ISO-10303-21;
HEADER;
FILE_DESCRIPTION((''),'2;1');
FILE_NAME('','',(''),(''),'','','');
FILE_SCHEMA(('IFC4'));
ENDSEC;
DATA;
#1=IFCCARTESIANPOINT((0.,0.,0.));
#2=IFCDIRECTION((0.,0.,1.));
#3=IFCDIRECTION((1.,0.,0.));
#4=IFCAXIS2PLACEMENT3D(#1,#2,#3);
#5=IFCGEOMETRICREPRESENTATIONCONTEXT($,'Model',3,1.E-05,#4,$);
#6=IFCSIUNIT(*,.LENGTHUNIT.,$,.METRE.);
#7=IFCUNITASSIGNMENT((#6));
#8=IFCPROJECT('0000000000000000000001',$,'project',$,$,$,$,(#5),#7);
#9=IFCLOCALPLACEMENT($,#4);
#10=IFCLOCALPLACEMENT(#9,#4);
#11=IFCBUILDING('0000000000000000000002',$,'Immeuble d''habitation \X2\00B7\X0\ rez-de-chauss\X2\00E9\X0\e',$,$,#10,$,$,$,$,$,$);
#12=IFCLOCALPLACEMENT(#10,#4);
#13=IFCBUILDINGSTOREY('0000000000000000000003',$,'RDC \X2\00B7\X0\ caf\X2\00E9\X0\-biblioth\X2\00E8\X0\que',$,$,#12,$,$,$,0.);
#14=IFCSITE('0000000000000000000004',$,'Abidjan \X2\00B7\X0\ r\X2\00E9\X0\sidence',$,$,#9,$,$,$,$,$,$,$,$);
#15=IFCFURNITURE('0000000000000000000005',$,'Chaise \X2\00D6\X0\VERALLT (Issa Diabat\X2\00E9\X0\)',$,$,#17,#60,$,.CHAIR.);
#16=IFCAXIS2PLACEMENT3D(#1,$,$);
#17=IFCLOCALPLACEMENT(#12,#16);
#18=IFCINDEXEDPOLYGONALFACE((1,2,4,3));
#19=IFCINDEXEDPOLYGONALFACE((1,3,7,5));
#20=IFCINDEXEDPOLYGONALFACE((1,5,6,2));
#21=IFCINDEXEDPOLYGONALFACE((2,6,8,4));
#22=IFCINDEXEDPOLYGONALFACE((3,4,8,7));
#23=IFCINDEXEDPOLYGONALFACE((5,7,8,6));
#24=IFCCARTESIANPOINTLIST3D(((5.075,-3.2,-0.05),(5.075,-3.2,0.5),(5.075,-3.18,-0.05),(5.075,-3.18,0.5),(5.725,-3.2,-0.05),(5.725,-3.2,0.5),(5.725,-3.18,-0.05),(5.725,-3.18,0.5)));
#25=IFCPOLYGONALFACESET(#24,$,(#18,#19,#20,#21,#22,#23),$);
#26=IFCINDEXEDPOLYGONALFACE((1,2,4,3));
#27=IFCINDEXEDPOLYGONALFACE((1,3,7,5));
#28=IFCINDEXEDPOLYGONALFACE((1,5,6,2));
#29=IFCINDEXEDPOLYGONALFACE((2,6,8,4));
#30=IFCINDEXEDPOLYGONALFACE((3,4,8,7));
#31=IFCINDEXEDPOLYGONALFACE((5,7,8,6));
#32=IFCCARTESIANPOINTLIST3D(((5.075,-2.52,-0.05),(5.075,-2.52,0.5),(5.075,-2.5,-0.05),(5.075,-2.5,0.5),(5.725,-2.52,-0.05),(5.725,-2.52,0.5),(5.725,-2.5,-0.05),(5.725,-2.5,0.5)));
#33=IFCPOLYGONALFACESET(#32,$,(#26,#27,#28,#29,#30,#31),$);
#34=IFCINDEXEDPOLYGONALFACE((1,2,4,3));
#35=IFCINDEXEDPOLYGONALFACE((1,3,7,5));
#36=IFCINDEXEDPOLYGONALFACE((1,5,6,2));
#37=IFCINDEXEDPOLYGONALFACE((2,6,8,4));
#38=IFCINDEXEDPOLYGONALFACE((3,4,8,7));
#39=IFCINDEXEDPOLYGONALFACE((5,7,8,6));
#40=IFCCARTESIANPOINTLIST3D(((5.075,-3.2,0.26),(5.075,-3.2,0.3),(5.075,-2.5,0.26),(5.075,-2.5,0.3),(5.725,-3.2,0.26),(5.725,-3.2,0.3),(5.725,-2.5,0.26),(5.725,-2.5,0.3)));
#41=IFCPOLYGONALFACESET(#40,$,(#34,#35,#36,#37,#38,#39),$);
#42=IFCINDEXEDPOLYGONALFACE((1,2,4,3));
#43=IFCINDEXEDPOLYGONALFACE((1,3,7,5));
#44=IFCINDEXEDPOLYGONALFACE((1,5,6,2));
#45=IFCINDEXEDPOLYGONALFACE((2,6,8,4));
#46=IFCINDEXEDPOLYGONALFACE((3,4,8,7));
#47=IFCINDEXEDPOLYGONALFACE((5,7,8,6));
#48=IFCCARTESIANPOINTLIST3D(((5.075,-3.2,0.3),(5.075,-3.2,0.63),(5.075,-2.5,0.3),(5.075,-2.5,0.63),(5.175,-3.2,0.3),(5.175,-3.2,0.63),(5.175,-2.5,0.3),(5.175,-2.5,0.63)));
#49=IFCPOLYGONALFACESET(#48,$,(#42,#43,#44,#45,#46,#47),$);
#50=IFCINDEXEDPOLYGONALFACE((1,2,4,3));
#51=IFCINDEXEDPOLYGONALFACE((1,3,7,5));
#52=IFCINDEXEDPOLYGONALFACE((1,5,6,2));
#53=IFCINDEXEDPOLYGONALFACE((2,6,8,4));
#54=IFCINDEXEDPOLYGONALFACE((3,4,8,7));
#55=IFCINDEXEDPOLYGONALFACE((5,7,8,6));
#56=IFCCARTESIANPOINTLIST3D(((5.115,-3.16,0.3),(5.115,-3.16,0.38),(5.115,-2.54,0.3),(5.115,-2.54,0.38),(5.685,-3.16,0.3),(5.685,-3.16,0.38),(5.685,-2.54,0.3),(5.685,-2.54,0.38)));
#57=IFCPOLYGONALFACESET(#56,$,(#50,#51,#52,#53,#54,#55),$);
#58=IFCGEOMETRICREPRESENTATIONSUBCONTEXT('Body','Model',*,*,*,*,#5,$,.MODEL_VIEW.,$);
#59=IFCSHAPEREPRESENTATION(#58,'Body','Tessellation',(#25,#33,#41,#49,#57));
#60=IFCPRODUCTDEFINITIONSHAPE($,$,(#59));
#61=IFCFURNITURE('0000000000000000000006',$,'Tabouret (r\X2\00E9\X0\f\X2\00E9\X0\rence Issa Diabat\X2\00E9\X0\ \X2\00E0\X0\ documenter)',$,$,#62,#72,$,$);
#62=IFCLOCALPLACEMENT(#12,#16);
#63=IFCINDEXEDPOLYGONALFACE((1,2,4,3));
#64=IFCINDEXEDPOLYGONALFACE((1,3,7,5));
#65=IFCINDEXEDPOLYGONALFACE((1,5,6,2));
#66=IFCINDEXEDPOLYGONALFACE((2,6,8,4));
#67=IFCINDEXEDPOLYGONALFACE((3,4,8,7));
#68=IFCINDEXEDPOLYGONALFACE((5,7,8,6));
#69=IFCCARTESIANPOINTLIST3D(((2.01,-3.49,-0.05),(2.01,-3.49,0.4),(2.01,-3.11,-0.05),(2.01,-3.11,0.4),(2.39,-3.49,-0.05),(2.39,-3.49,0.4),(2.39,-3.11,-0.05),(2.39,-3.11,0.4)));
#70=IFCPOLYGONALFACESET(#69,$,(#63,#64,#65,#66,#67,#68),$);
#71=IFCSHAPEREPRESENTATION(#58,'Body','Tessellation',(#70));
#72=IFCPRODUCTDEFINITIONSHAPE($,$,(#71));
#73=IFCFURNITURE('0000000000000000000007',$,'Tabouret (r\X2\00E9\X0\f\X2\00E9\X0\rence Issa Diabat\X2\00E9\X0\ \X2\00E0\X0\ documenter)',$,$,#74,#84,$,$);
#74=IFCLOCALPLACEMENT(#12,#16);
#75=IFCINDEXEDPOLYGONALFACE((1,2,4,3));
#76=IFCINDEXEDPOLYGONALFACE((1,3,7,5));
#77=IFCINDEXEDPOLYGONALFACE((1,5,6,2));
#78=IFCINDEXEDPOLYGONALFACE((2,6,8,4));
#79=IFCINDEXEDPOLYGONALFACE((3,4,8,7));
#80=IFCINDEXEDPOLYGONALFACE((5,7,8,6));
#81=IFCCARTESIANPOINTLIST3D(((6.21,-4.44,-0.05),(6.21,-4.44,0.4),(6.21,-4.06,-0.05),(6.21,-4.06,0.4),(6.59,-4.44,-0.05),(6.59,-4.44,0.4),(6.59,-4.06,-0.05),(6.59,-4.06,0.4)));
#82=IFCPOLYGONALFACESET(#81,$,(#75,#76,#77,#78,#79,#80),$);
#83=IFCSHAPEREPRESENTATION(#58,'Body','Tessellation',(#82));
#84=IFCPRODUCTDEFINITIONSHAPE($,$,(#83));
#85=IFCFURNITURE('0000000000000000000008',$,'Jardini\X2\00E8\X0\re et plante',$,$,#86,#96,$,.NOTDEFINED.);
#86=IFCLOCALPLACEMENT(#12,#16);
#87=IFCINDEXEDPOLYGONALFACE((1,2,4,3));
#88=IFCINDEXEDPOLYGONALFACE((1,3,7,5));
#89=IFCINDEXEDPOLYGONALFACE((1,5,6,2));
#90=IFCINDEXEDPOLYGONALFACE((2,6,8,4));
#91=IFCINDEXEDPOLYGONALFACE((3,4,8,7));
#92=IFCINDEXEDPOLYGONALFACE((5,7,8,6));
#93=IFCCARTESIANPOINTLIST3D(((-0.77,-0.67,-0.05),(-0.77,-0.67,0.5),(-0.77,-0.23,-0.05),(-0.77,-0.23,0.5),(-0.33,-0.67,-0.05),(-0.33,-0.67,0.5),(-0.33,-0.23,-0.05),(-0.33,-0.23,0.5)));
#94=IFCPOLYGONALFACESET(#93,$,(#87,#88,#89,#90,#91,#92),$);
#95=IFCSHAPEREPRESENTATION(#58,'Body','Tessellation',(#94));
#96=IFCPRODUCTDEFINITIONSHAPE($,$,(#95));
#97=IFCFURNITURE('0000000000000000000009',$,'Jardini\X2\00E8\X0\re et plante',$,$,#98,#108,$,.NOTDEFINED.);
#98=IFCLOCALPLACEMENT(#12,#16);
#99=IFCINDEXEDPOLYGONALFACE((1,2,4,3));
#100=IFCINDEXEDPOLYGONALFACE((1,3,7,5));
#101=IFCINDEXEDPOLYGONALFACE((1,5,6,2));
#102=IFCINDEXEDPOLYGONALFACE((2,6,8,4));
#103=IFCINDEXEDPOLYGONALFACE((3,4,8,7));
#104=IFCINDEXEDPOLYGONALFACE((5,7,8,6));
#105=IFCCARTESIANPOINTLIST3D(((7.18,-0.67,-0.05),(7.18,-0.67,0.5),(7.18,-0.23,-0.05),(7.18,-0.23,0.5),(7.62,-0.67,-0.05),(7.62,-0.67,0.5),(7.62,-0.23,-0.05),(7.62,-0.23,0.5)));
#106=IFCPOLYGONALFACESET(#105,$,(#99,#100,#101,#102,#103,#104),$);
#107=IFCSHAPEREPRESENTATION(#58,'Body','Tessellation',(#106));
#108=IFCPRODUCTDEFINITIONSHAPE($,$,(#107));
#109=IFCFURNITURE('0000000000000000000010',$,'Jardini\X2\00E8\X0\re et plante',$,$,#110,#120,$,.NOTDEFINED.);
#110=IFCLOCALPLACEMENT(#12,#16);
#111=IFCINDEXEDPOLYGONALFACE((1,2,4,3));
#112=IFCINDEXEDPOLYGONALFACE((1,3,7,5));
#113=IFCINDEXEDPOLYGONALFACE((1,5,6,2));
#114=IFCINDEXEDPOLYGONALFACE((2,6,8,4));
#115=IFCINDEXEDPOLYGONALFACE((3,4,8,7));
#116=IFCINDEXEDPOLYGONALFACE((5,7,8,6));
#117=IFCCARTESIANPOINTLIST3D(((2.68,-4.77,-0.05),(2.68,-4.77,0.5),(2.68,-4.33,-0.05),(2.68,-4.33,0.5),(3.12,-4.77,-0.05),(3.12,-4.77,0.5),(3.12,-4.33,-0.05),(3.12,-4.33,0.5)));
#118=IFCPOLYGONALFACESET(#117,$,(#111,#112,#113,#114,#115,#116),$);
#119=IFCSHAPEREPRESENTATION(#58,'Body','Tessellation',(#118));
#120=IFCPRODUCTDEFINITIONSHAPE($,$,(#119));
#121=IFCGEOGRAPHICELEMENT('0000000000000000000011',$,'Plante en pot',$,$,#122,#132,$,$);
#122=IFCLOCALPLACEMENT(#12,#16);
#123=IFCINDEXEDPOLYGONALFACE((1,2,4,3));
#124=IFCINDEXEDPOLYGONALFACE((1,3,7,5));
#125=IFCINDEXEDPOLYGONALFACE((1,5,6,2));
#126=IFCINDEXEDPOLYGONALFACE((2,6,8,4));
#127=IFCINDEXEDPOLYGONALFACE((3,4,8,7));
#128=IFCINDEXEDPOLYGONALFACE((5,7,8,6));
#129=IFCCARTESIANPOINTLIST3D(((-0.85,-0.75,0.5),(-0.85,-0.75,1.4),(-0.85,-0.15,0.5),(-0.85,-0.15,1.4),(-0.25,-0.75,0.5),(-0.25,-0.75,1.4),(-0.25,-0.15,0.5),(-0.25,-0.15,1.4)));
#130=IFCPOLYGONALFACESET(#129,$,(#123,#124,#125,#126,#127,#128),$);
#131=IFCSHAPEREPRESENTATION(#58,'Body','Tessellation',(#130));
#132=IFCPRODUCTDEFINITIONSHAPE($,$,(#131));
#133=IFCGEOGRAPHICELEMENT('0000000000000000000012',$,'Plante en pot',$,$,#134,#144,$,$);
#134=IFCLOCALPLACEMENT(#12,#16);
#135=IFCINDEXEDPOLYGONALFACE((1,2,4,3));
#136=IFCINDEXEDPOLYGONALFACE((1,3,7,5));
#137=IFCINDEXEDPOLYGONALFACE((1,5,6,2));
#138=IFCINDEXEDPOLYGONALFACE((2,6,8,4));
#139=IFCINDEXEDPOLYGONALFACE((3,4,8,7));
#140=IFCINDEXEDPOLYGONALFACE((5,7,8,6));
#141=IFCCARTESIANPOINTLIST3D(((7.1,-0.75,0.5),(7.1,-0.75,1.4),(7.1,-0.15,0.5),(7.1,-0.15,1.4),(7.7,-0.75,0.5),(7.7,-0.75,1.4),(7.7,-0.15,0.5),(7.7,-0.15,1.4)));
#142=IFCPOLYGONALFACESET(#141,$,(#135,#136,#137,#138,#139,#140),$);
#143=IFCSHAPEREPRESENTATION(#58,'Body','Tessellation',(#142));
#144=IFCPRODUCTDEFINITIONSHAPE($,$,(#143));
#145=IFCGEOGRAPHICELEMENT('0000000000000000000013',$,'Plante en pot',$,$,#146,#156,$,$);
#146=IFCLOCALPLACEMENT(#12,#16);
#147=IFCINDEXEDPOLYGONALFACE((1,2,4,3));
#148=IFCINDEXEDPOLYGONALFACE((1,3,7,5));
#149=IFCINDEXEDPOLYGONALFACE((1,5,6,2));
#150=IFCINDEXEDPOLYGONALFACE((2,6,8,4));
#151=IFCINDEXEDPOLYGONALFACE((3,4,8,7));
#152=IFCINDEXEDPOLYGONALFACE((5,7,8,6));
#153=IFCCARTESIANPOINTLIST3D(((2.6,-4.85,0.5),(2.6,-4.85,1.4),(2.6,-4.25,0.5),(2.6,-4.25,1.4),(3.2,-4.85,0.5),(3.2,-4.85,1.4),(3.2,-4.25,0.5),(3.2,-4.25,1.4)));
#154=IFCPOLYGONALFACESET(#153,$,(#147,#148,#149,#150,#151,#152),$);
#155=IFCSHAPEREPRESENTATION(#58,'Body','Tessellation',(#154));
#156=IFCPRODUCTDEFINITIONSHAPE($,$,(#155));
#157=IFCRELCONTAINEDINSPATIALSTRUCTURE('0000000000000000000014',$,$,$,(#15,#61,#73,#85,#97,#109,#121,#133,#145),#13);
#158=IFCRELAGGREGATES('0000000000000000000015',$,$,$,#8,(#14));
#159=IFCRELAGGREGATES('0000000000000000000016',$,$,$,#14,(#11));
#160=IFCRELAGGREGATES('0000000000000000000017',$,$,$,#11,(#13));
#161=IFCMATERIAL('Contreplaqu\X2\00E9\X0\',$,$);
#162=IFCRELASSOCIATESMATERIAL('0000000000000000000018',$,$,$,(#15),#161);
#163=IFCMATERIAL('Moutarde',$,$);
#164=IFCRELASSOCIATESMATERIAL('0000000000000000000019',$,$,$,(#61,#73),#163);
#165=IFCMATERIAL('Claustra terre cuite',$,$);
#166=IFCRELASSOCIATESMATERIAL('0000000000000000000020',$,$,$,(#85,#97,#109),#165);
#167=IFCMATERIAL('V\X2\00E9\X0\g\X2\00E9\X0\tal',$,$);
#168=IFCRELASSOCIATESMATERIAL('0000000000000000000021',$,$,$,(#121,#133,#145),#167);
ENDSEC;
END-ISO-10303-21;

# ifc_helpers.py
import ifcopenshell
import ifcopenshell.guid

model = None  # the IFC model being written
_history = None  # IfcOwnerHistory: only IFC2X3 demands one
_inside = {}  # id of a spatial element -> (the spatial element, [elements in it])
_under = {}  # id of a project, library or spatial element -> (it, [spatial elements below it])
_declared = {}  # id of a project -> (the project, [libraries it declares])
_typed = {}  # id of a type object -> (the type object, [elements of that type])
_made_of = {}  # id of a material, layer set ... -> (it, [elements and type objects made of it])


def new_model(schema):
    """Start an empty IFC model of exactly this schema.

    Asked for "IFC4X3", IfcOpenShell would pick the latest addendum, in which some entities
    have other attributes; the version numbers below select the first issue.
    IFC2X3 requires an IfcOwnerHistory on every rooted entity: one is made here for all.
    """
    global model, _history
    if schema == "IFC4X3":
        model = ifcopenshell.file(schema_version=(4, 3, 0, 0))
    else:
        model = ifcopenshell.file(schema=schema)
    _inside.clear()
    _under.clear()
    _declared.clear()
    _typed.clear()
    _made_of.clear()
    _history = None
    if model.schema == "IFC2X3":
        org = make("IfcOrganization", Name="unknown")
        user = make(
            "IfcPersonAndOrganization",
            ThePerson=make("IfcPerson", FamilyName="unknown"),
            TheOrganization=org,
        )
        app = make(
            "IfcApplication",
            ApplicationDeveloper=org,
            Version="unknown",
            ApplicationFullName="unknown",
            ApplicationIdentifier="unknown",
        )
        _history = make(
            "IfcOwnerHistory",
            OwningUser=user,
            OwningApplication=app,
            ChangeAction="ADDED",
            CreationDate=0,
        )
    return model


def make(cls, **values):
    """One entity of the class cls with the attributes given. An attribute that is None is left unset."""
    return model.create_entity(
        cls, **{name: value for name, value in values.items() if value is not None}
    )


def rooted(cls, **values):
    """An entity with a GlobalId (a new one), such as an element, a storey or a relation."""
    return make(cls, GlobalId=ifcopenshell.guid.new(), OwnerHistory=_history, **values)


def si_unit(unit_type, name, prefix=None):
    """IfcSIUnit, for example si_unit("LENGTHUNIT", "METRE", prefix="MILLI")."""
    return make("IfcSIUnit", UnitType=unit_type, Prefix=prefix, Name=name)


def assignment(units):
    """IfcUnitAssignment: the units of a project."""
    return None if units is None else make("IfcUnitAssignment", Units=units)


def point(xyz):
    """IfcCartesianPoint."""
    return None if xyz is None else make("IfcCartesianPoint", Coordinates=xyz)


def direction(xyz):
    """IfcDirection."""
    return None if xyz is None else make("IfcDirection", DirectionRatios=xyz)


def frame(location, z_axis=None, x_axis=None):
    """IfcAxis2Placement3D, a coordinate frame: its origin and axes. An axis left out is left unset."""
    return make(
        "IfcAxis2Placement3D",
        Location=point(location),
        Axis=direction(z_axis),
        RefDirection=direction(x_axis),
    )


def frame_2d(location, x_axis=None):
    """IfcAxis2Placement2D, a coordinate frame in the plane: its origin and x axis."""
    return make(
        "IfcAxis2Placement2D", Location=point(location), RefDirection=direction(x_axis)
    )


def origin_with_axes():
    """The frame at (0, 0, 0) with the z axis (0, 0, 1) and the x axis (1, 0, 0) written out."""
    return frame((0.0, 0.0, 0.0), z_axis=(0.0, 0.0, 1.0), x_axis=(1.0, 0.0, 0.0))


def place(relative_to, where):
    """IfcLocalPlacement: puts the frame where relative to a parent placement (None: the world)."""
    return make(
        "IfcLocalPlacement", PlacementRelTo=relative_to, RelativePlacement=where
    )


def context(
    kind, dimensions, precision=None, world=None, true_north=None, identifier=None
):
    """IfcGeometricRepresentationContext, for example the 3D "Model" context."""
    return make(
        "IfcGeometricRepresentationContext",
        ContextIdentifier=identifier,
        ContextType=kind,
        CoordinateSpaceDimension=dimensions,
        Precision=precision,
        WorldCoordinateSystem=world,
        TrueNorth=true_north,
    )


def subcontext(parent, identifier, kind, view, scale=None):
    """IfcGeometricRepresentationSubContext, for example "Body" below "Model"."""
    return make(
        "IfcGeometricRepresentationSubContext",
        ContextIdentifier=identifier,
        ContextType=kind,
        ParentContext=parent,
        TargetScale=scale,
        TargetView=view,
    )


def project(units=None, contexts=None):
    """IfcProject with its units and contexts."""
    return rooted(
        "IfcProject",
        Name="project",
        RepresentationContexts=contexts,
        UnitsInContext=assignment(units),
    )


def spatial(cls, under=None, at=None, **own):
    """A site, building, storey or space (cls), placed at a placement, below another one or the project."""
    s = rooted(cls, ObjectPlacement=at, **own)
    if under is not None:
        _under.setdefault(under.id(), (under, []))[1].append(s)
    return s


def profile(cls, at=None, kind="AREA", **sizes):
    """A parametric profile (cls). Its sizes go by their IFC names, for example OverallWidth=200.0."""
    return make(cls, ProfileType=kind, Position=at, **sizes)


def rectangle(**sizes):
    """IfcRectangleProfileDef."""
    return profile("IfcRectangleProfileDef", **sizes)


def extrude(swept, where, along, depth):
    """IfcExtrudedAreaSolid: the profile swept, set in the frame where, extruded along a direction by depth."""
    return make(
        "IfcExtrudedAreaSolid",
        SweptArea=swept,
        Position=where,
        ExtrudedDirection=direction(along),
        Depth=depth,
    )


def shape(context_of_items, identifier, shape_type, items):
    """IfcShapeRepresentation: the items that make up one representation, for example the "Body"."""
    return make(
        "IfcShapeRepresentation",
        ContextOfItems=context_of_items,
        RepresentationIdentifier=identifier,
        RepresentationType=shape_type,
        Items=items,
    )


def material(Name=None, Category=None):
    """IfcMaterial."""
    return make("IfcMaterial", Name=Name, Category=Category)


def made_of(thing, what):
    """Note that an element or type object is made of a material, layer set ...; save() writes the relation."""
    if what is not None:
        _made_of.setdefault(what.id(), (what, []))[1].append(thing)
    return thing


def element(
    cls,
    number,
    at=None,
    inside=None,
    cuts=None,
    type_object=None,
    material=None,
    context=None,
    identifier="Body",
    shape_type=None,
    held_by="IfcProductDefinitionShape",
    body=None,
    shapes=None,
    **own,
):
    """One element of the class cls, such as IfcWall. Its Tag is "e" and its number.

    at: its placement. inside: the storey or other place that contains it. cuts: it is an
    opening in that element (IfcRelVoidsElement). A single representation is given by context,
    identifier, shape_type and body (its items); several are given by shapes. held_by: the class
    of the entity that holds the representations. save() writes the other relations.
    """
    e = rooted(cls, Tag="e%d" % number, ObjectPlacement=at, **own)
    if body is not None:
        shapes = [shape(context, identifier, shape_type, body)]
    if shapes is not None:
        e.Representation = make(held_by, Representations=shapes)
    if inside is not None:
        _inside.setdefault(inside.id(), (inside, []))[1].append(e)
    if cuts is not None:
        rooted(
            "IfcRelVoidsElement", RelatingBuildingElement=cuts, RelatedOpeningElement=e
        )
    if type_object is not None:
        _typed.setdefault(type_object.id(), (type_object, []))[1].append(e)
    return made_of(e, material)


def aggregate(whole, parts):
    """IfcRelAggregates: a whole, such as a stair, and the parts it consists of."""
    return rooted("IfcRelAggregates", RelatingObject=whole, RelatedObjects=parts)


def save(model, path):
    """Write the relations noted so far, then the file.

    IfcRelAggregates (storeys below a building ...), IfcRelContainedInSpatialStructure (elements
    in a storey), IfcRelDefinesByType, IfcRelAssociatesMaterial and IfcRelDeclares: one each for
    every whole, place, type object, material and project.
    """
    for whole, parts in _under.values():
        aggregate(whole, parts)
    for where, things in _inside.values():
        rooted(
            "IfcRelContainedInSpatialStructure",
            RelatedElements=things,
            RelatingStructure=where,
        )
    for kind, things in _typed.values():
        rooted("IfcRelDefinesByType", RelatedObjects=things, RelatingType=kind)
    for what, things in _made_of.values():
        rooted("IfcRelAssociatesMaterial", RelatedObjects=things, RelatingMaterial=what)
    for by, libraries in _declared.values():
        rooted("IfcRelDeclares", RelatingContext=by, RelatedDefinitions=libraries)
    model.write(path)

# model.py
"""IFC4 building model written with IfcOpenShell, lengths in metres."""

from ifc_helpers import new_model, si_unit, frame, frame_2d, origin_with_axes, place, context, subcontext, project, spatial, rectangle, extrude, material, element, save


model = new_model("IFC4")

# Units and contexts
model_context = context("Model", 3, precision=1e-05, world=origin_with_axes())
body_context = subcontext(model_context, "Body", "Model", "MODEL_VIEW")
ifc_project = project(units=[si_unit("LENGTHUNIT", "METRE")], contexts=[model_context])

# Site, building, storey
site_placement = place(None, origin_with_axes())
site = spatial("IfcSite", under=ifc_project, at=site_placement, Name="Abidjan · résidence")
building_placement = place(site_placement, origin_with_axes())
building = spatial("IfcBuilding", under=site, at=building_placement, Name="Immeuble d'habitation · rez-de-chaussée")
storey_placement = place(building_placement, origin_with_axes())
storey = spatial("IfcBuildingStorey", under=building, at=storey_placement, Name="RDC · café-bibliothèque", Elevation=0.0)

# Furniture
ifc_material_1 = material(Name="Contreplaqué")
furniture_1_placement = place(storey_placement, origin_with_axes())
element("IfcFurniture", 1, at=furniture_1_placement, inside=storey, material=ifc_material_1, Name="Chaise ÖVERALLT (Issa Diabaté)", PredefinedType="CHAIR", context=body_context, shape_type="SweptSolid", body=[
    extrude(rectangle(XDim=0.65, YDim=0.02, at=frame_2d((5.4, -3.19))), frame((0.0, 0.0, -0.05)), (0.0, 0.0, 1.0), 0.55),
    extrude(rectangle(XDim=0.65, YDim=0.02, at=frame_2d((5.4, -2.51))), frame((0.0, 0.0, -0.05)), (0.0, 0.0, 1.0), 0.55),
    extrude(rectangle(XDim=0.65, YDim=0.7, at=frame_2d((5.4, -2.85))), frame((0.0, 0.0, 0.26)), (0.0, 0.0, 1.0), 0.04),
    extrude(rectangle(XDim=0.1, YDim=0.7, at=frame_2d((5.125, -2.85))), frame((0.0, 0.0, 0.3)), (0.0, 0.0, 1.0), 0.33),
    extrude(rectangle(XDim=0.57, YDim=0.62, at=frame_2d((5.4, -2.85))), frame((0.0, 0.0, 0.3)), (0.0, 0.0, 1.0), 0.08),
])
ifc_material_2 = material(Name="Moutarde")
furniture_2_placement = place(storey_placement, origin_with_axes())
element("IfcFurniture", 2, at=furniture_2_placement, inside=storey, material=ifc_material_2, Name="Tabouret (référence Issa Diabaté à documenter)", context=body_context, shape_type="SweptSolid", body=[
    extrude(rectangle(XDim=0.38, YDim=0.38, at=frame_2d((2.2, -3.3))), frame((0.0, 0.0, -0.05)), (0.0, 0.0, 1.0), 0.45),
])
furniture_3_placement = place(storey_placement, origin_with_axes())
element("IfcFurniture", 3, at=furniture_3_placement, inside=storey, material=ifc_material_2, Name="Tabouret (référence Issa Diabaté à documenter)", context=body_context, shape_type="SweptSolid", body=[
    extrude(rectangle(XDim=0.38, YDim=0.38, at=frame_2d((6.4, -4.25))), frame((0.0, 0.0, -0.05)), (0.0, 0.0, 1.0), 0.45),
])
ifc_material_3 = material(Name="Claustra terre cuite")
furniture_4_placement = place(storey_placement, origin_with_axes())
element("IfcFurniture", 4, at=furniture_4_placement, inside=storey, material=ifc_material_3, Name="Jardinière et plante", PredefinedType="NOTDEFINED", context=body_context, shape_type="SweptSolid", body=[
    extrude(rectangle(XDim=0.44, YDim=0.44, at=frame_2d((-0.55, -0.45))), frame((0.0, 0.0, -0.05)), (0.0, 0.0, 1.0), 0.55),
])
furniture_5_placement = place(storey_placement, origin_with_axes())
element("IfcFurniture", 5, at=furniture_5_placement, inside=storey, material=ifc_material_3, Name="Jardinière et plante", PredefinedType="NOTDEFINED", context=body_context, shape_type="SweptSolid", body=[
    extrude(rectangle(XDim=0.44, YDim=0.44, at=frame_2d((7.4, -0.45))), frame((0.0, 0.0, -0.05)), (0.0, 0.0, 1.0), 0.55),
])
furniture_6_placement = place(storey_placement, origin_with_axes())
element("IfcFurniture", 6, at=furniture_6_placement, inside=storey, material=ifc_material_3, Name="Jardinière et plante", PredefinedType="NOTDEFINED", context=body_context, shape_type="SweptSolid", body=[
    extrude(rectangle(XDim=0.44, YDim=0.44, at=frame_2d((2.9, -4.55))), frame((0.0, 0.0, -0.05)), (0.0, 0.0, 1.0), 0.55),
])

# Geographic elements
ifc_material_4 = material(Name="Végétal")
geographic_element_1_placement = place(storey_placement, origin_with_axes())
element("IfcGeographicElement", 7, at=geographic_element_1_placement, inside=storey, material=ifc_material_4, Name="Plante en pot", context=body_context, shape_type="SweptSolid", body=[
    extrude(rectangle(XDim=0.6, YDim=0.6, at=frame_2d((-0.55, -0.45))), frame((0.0, 0.0, 0.5)), (0.0, 0.0, 1.0), 0.9),
])
geographic_element_2_placement = place(storey_placement, origin_with_axes())
element("IfcGeographicElement", 8, at=geographic_element_2_placement, inside=storey, material=ifc_material_4, Name="Plante en pot", context=body_context, shape_type="SweptSolid", body=[
    extrude(rectangle(XDim=0.6, YDim=0.6, at=frame_2d((7.4, -0.45))), frame((0.0, 0.0, 0.5)), (0.0, 0.0, 1.0), 0.9),
])
geographic_element_3_placement = place(storey_placement, origin_with_axes())
element("IfcGeographicElement", 9, at=geographic_element_3_placement, inside=storey, material=ifc_material_4, Name="Plante en pot", context=body_context, shape_type="SweptSolid", body=[
    extrude(rectangle(XDim=0.6, YDim=0.6, at=frame_2d((2.9, -4.55))), frame((0.0, 0.0, 0.5)), (0.0, 0.0, 1.0), 0.9),
])

save(model, "model.ifc")
